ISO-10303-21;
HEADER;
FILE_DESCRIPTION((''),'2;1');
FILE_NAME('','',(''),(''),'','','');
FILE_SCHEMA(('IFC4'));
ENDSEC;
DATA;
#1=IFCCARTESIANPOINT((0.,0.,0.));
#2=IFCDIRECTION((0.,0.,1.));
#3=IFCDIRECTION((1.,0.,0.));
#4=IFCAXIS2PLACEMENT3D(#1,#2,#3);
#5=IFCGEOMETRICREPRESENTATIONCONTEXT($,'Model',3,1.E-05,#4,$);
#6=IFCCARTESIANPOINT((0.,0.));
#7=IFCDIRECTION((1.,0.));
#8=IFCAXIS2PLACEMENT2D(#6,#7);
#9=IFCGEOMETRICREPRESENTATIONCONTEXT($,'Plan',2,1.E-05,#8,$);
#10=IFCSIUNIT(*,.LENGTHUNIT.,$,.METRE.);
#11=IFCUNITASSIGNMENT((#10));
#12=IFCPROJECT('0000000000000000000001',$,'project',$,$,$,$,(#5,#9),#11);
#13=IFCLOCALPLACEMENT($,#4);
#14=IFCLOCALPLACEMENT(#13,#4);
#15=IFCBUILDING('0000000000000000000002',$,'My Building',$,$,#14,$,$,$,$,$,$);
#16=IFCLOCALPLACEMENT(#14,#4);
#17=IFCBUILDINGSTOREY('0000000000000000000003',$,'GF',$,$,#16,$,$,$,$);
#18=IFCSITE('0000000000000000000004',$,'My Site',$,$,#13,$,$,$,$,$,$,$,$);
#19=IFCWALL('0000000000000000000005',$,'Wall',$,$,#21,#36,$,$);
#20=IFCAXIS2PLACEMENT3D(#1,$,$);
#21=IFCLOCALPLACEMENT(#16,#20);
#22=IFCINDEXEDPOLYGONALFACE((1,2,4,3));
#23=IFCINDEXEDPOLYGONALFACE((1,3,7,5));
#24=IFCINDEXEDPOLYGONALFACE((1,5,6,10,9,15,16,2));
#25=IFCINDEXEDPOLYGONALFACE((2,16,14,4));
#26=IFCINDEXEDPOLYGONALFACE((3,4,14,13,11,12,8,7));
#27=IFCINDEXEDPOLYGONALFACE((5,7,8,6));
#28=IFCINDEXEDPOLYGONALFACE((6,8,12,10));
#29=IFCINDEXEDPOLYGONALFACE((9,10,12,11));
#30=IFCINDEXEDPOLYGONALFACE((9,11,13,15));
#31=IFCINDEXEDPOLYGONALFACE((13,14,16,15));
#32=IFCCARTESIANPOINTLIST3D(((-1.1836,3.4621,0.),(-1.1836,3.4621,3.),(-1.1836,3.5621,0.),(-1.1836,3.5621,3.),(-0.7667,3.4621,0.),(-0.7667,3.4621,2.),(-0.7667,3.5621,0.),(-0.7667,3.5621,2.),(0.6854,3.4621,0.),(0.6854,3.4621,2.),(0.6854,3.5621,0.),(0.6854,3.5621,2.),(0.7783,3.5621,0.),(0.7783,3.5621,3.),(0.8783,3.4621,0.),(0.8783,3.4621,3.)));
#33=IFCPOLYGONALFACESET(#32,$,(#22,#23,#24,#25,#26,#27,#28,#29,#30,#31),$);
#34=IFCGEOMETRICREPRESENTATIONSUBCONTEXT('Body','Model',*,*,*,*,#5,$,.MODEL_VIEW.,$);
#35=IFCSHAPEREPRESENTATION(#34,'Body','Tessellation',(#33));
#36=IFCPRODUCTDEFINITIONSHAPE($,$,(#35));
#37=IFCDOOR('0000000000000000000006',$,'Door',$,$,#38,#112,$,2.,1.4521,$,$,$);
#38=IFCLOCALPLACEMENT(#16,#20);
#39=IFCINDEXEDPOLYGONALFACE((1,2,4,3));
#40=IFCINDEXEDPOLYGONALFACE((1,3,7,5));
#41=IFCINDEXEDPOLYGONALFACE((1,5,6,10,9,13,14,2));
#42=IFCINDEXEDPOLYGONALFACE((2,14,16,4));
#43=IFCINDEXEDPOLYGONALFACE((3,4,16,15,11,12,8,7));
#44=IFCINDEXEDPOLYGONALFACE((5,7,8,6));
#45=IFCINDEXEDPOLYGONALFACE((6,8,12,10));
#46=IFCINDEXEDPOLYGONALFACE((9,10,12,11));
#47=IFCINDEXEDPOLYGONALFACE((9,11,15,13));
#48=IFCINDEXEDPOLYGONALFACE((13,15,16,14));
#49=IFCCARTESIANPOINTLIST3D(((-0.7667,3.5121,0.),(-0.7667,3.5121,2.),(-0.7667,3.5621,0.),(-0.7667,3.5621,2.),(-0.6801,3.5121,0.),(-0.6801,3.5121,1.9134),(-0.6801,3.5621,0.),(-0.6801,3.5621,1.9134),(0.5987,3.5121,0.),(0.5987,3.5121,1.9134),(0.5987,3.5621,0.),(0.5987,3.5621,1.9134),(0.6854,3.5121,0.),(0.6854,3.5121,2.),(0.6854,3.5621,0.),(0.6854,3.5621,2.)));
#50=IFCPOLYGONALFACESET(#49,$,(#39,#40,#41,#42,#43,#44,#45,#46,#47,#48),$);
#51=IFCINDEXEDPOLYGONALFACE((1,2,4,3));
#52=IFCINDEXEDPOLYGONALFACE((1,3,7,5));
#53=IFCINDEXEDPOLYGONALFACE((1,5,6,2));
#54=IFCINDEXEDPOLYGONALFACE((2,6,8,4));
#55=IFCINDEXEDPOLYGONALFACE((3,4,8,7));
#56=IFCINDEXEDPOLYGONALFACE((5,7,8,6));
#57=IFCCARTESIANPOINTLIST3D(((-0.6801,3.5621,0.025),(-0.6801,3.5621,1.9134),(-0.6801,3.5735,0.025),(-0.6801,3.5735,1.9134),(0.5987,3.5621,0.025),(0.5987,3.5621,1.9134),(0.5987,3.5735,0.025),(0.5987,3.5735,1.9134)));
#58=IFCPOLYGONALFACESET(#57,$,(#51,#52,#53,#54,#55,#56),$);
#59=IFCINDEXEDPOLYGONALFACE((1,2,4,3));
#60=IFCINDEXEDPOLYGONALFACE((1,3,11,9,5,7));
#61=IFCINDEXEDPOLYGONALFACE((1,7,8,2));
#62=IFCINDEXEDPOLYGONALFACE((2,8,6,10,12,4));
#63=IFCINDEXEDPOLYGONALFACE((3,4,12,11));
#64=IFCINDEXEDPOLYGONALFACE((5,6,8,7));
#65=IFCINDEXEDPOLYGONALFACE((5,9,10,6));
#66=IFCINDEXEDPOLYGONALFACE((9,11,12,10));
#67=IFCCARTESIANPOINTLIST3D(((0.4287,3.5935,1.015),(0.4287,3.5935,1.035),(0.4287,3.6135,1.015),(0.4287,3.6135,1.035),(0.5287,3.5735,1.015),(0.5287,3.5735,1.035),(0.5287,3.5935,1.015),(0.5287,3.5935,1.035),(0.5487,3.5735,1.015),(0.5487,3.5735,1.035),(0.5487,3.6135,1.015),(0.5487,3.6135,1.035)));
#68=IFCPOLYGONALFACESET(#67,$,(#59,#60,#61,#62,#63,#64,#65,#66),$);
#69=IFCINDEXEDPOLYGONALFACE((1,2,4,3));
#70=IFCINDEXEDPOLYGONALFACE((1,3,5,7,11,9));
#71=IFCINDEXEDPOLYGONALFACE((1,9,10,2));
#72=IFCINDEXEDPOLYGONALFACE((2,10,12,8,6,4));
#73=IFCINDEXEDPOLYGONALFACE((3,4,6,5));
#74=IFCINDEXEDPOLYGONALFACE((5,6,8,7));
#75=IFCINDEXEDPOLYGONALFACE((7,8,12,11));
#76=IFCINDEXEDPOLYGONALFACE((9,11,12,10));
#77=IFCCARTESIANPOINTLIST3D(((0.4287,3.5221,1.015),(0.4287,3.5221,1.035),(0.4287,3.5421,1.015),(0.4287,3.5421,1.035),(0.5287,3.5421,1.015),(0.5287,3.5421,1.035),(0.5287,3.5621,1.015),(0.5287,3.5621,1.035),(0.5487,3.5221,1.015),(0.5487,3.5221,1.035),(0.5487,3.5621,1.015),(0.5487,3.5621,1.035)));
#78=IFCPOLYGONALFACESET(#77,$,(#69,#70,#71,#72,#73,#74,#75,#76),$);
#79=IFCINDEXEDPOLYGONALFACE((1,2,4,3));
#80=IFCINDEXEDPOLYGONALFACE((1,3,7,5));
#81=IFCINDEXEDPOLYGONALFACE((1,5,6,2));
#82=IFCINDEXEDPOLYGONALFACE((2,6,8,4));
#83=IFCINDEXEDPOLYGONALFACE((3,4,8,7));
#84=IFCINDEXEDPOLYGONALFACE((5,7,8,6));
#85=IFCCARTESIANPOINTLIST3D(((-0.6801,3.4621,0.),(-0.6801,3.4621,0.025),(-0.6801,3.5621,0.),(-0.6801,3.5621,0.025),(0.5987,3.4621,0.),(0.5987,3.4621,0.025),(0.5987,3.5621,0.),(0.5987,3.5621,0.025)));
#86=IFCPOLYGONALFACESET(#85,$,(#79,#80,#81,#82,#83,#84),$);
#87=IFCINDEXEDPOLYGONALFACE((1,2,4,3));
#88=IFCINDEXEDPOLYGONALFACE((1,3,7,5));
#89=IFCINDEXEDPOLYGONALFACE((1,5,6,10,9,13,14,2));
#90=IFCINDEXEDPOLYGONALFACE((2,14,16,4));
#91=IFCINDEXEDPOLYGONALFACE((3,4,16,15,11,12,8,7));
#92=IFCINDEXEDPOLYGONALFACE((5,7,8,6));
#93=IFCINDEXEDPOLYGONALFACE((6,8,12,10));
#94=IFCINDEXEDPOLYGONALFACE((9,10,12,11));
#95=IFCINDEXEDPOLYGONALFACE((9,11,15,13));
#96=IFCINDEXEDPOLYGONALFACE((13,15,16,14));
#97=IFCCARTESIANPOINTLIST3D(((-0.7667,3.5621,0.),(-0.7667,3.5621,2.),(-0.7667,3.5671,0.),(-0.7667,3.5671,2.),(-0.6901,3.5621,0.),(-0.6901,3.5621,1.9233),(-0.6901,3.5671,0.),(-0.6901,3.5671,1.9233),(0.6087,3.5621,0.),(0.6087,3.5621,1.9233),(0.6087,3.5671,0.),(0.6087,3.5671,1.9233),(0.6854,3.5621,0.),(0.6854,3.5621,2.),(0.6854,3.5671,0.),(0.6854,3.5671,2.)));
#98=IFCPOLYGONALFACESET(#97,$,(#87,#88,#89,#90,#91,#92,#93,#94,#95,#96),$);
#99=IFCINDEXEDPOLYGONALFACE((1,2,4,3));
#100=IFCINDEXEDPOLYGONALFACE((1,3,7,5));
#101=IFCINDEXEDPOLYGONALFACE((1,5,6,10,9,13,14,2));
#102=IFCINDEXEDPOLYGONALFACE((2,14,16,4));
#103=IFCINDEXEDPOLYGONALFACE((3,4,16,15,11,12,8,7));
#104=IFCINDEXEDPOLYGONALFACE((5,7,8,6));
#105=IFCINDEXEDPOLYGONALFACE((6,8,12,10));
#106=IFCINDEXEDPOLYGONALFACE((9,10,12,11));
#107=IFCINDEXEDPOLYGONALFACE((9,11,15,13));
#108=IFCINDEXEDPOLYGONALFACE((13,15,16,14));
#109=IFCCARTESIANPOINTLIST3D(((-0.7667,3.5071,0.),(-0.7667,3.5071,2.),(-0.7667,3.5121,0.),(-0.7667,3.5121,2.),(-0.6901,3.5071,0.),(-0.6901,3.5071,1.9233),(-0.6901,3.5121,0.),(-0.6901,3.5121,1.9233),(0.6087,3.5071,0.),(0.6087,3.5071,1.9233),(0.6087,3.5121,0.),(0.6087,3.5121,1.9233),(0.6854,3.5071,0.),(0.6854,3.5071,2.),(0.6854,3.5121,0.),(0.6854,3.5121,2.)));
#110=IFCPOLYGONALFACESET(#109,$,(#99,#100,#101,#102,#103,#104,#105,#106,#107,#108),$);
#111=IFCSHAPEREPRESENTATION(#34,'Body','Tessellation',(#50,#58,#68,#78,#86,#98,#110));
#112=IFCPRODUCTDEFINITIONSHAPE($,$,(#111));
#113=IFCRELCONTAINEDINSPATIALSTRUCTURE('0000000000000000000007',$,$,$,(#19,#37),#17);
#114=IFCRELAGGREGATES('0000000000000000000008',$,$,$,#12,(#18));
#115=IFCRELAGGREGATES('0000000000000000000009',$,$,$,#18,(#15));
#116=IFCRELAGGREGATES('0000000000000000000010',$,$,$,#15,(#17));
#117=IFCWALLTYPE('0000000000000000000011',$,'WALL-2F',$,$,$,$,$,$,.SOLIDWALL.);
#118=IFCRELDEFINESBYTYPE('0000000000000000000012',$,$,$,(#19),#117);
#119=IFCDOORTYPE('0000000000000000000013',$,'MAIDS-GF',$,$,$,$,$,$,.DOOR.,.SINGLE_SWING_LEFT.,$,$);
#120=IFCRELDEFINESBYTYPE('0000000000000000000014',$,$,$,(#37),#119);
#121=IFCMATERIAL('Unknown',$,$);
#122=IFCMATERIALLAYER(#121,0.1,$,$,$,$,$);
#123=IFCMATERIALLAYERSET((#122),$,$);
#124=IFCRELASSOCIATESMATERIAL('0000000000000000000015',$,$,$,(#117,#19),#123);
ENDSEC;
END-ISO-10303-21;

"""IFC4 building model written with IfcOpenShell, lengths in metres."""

from ifc_helpers import new_model, entity, si_unit, frame, origin_with_axes, origin_2d_with_axis, place, context, subcontext, project, spatial, line, indexed_curve, outline, extrude, shape, source, transform, mapped, material, layer, layer_set, layer_usage, type_object, type_shapes, element, fill, save


model = new_model("IFC4")

# Units and contexts
model_context = context("Model", 3, precision=1e-05, world=origin_with_axes())
plan_context = context("Plan", 2, precision=1e-05, world=origin_2d_with_axis())
body_context_1 = subcontext(model_context, "Body", "Model", "MODEL_VIEW")
body_context_2 = subcontext(plan_context, "Body", "Plan", "PLAN_VIEW")
ifc_project = project(units=[si_unit("LENGTHUNIT", "METRE")], contexts=[model_context, plan_context])

# Site, building, storey
site_placement = place(None, origin_with_axes())
site = spatial("IfcSite", under=ifc_project, at=site_placement, Name="My Site")
building_placement = place(site_placement, origin_with_axes())
building = spatial("IfcBuilding", under=site, at=building_placement, Name="My Building")
storey_placement = place(building_placement, origin_with_axes())
storey = spatial("IfcBuildingStorey", under=building, at=storey_placement, Name="GF")

# Shared definitions
ifc_material = material(Name="Unknown")
ifc_layer = layer(ifc_material, 0.1)
ifc_layer_set = layer_set([ifc_layer])
wall_type = type_object("IfcWallType", Name="WALL-2F", PredefinedType="SOLIDWALL", material=ifc_layer_set)

# Wall, opening, door
ifc_layer_usage_1 = layer_usage(ifc_layer_set, "AXIS2", "POSITIVE", 0.0)
wall_1_placement = place(storey_placement, frame((0.7783, 3.5621, 0.0), z_axis=(0.0, 0.0, 1.0), x_axis=(-1.0, 0.0, 0.0)))
wall_1 = element("IfcWall", 1, at=wall_1_placement, inside=storey, type_object=wall_type, material=ifc_layer_usage_1, Name="Wall", context=body_context_1, shape_type="SweptSolid", body=[
    extrude(outline(indexed_curve([(0.0, 0.0), (-0.1, 0.1), (1.962, 0.1), (1.962, 0.0)], segments=[line(1, 2, 3, 4, 1)])), origin_with_axes(), (0.0, 0.0, 1.0), 3.0),
])
shared_shape_1 = source(origin_with_axes(), body_context_1, "Body", "SweptSolid", [
    extrude(outline(indexed_curve([(0.0, 0.0), (1.4521, 0.0), (1.4521, 2.0), (0.0, 2.0)], segments=[line(1, 2, 3, 4, 1)])), frame((0.0, -0.6, 0.0), z_axis=(0.0, -1.0, 0.0), x_axis=(1.0, 0.0, 0.0)), (0.0, 0.0, -1.0), 1.2),
])
opening_1_placement = place(wall_1_placement, frame((0.093, 0.0, 0.0), z_axis=(0.0, 0.0, 1.0), x_axis=(1.0, 0.0, 0.0)))
opening_1 = element("IfcOpeningElement", 2, at=opening_1_placement, cuts=wall_1, PredefinedType="OPENING", context=body_context_1, shape_type="MappedRepresentation", body=[
    mapped(shared_shape_1, transform((0.0, 0.0, 0.0), x_axis=(1.0, 0.0, 0.0), y_axis=(0.0, 1.0, 0.0), z_axis=(0.0, 0.0, 1.0), scale=1.0)),
])
door_type_1 = type_object("IfcDoorType", Name="MAIDS-GF", OperationType="SINGLE_SWING_LEFT", PredefinedType="DOOR")
shared_shape_2 = source(origin_with_axes(), body_context_1, "Body", "SweptSolid", [
    extrude(outline(indexed_curve([(0.0, 0.0), (0.0, 2.0), (1.4521, 2.0), (1.4521, 0.0), (1.3655, 0.0), (1.3655, 1.9134), (0.0866, 1.9134), (0.0866, 0.0)], segments=[line(1, 2, 3, 4, 5, 6, 7, 8, 1)])), frame((0.0, 0.0, 0.0), z_axis=(0.0, -1.0, 0.0), x_axis=(1.0, 0.0, 0.0)), (0.0, 0.0, -1.0), 0.05),
    extrude(outline(indexed_curve([(0.0, 0.0), (1.2788, 0.0), (1.2788, 0.0114), (0.0, 0.0114)], segments=[line(1, 2, 3, 4, 1)])), frame((0.0866, -0.0114, 0.025), z_axis=(0.0, 0.0, 1.0), x_axis=(1.0, 0.0, 0.0)), (0.0, 0.0, 1.0), 1.8884),
    extrude(outline(indexed_curve([(0.0, 0.0), (0.0, -0.04), (0.12, -0.04), (0.12, -0.02), (0.02, -0.02), (0.02, 0.0)], segments=[line(1, 2, 3, 4, 5, 6, 1)])), frame((0.1366, -0.0114, 1.015), z_axis=(0.0, 0.0, 1.0), x_axis=(1.0, 0.0, 0.0)), (0.0, 0.0, 1.0), 0.02),
    extrude(outline(indexed_curve([(0.0, 0.0), (0.0, 0.04), (0.12, 0.04), (0.12, 0.02), (0.02, 0.02), (0.02, 0.0)], segments=[line(1, 2, 3, 4, 5, 6, 1)])), frame((0.1366, 0.0, 1.015), z_axis=(0.0, 0.0, 1.0), x_axis=(1.0, 0.0, 0.0)), (0.0, 0.0, 1.0), 0.02),
    extrude(outline(indexed_curve([(0.0, 0.0), (1.2788, 0.0), (1.2788, 0.1), (0.0, 0.1)], segments=[line(1, 2, 3, 4, 1)])), frame((0.0866, 0.0, 0.0), z_axis=(0.0, 0.0, 1.0), x_axis=(1.0, 0.0, 0.0)), (0.0, 0.0, 1.0), 0.025),
    extrude(outline(indexed_curve([(0.0, 0.0), (0.0, 2.0), (1.4521, 2.0), (1.4521, 0.0), (1.3754, 0.0), (1.3754, 1.9233), (0.0767, 1.9233), (0.0767, 0.0)], segments=[line(1, 2, 3, 4, 5, 6, 7, 8, 1)])), frame((0.0, -0.005, 0.0), z_axis=(0.0, -1.0, 0.0), x_axis=(1.0, 0.0, 0.0)), (0.0, 0.0, -1.0), 0.005),
    extrude(outline(indexed_curve([(0.0, 0.0), (0.0, 2.0), (1.4521, 2.0), (1.4521, 0.0), (1.3754, 0.0), (1.3754, 1.9233), (0.0767, 1.9233), (0.0767, 0.0)], segments=[line(1, 2, 3, 4, 5, 6, 7, 8, 1)])), frame((0.0, 0.05, 0.0), z_axis=(0.0, -1.0, 0.0), x_axis=(1.0, 0.0, 0.0)), (0.0, 0.0, -1.0), 0.005),
])
shared_shape_3 = source(origin_with_axes(), body_context_2, "Body", "Curve2D", [
    entity("IfcIndexedPolyCurve", entity("IfcCartesianPointList2D", [[0.0, 0.0], [0.0866, 0.0], [0.0866, 0.05], [0.0, 0.05]]), [entity("IfcLineIndex", [1, 2, 3, 4, 1])]),
    entity("IfcIndexedPolyCurve", entity("IfcCartesianPointList2D", [[1.4521, 0.0], [1.3655, 0.0], [1.3655, 0.05], [1.4521, 0.05]]), [entity("IfcLineIndex", [1, 2, 3, 4, 1])]),
    entity("IfcIndexedPolyCurve", entity("IfcCartesianPointList2D", [[2.0049, -0.0114], [0.7261, -0.0114], [0.7261, 0.0], [2.0049, 0.0]]), [entity("IfcLineIndex", [1, 2, 3, 4, 1])]),
])
type_shapes(door_type_1, [shared_shape_2, shared_shape_3])
door_1_placement = place(opening_1_placement, origin_with_axes())
door_1 = element("IfcDoor", 3, at=door_1_placement, inside=storey, type_object=door_type_1, Name="Door", OverallHeight=2.0, OverallWidth=1.4521, shapes=[
    shape(body_context_1, "Body", "MappedRepresentation", [mapped(shared_shape_2, transform((0.0, 0.0, 0.0), x_axis=(1.0, 0.0, 0.0), y_axis=(0.0, 1.0, 0.0), z_axis=(0.0, 0.0, 1.0), scale=1.0))]),
    shape(body_context_2, "Body", "MappedRepresentation", [mapped(shared_shape_3, transform((0.0, 0.0, 0.0), x_axis=(1.0, 0.0, 0.0), y_axis=(0.0, 1.0, 0.0), z_axis=(0.0, 0.0, 1.0), scale=1.0))]),
])
fill(opening_1, door_1)

save(model, "model.ifc")
